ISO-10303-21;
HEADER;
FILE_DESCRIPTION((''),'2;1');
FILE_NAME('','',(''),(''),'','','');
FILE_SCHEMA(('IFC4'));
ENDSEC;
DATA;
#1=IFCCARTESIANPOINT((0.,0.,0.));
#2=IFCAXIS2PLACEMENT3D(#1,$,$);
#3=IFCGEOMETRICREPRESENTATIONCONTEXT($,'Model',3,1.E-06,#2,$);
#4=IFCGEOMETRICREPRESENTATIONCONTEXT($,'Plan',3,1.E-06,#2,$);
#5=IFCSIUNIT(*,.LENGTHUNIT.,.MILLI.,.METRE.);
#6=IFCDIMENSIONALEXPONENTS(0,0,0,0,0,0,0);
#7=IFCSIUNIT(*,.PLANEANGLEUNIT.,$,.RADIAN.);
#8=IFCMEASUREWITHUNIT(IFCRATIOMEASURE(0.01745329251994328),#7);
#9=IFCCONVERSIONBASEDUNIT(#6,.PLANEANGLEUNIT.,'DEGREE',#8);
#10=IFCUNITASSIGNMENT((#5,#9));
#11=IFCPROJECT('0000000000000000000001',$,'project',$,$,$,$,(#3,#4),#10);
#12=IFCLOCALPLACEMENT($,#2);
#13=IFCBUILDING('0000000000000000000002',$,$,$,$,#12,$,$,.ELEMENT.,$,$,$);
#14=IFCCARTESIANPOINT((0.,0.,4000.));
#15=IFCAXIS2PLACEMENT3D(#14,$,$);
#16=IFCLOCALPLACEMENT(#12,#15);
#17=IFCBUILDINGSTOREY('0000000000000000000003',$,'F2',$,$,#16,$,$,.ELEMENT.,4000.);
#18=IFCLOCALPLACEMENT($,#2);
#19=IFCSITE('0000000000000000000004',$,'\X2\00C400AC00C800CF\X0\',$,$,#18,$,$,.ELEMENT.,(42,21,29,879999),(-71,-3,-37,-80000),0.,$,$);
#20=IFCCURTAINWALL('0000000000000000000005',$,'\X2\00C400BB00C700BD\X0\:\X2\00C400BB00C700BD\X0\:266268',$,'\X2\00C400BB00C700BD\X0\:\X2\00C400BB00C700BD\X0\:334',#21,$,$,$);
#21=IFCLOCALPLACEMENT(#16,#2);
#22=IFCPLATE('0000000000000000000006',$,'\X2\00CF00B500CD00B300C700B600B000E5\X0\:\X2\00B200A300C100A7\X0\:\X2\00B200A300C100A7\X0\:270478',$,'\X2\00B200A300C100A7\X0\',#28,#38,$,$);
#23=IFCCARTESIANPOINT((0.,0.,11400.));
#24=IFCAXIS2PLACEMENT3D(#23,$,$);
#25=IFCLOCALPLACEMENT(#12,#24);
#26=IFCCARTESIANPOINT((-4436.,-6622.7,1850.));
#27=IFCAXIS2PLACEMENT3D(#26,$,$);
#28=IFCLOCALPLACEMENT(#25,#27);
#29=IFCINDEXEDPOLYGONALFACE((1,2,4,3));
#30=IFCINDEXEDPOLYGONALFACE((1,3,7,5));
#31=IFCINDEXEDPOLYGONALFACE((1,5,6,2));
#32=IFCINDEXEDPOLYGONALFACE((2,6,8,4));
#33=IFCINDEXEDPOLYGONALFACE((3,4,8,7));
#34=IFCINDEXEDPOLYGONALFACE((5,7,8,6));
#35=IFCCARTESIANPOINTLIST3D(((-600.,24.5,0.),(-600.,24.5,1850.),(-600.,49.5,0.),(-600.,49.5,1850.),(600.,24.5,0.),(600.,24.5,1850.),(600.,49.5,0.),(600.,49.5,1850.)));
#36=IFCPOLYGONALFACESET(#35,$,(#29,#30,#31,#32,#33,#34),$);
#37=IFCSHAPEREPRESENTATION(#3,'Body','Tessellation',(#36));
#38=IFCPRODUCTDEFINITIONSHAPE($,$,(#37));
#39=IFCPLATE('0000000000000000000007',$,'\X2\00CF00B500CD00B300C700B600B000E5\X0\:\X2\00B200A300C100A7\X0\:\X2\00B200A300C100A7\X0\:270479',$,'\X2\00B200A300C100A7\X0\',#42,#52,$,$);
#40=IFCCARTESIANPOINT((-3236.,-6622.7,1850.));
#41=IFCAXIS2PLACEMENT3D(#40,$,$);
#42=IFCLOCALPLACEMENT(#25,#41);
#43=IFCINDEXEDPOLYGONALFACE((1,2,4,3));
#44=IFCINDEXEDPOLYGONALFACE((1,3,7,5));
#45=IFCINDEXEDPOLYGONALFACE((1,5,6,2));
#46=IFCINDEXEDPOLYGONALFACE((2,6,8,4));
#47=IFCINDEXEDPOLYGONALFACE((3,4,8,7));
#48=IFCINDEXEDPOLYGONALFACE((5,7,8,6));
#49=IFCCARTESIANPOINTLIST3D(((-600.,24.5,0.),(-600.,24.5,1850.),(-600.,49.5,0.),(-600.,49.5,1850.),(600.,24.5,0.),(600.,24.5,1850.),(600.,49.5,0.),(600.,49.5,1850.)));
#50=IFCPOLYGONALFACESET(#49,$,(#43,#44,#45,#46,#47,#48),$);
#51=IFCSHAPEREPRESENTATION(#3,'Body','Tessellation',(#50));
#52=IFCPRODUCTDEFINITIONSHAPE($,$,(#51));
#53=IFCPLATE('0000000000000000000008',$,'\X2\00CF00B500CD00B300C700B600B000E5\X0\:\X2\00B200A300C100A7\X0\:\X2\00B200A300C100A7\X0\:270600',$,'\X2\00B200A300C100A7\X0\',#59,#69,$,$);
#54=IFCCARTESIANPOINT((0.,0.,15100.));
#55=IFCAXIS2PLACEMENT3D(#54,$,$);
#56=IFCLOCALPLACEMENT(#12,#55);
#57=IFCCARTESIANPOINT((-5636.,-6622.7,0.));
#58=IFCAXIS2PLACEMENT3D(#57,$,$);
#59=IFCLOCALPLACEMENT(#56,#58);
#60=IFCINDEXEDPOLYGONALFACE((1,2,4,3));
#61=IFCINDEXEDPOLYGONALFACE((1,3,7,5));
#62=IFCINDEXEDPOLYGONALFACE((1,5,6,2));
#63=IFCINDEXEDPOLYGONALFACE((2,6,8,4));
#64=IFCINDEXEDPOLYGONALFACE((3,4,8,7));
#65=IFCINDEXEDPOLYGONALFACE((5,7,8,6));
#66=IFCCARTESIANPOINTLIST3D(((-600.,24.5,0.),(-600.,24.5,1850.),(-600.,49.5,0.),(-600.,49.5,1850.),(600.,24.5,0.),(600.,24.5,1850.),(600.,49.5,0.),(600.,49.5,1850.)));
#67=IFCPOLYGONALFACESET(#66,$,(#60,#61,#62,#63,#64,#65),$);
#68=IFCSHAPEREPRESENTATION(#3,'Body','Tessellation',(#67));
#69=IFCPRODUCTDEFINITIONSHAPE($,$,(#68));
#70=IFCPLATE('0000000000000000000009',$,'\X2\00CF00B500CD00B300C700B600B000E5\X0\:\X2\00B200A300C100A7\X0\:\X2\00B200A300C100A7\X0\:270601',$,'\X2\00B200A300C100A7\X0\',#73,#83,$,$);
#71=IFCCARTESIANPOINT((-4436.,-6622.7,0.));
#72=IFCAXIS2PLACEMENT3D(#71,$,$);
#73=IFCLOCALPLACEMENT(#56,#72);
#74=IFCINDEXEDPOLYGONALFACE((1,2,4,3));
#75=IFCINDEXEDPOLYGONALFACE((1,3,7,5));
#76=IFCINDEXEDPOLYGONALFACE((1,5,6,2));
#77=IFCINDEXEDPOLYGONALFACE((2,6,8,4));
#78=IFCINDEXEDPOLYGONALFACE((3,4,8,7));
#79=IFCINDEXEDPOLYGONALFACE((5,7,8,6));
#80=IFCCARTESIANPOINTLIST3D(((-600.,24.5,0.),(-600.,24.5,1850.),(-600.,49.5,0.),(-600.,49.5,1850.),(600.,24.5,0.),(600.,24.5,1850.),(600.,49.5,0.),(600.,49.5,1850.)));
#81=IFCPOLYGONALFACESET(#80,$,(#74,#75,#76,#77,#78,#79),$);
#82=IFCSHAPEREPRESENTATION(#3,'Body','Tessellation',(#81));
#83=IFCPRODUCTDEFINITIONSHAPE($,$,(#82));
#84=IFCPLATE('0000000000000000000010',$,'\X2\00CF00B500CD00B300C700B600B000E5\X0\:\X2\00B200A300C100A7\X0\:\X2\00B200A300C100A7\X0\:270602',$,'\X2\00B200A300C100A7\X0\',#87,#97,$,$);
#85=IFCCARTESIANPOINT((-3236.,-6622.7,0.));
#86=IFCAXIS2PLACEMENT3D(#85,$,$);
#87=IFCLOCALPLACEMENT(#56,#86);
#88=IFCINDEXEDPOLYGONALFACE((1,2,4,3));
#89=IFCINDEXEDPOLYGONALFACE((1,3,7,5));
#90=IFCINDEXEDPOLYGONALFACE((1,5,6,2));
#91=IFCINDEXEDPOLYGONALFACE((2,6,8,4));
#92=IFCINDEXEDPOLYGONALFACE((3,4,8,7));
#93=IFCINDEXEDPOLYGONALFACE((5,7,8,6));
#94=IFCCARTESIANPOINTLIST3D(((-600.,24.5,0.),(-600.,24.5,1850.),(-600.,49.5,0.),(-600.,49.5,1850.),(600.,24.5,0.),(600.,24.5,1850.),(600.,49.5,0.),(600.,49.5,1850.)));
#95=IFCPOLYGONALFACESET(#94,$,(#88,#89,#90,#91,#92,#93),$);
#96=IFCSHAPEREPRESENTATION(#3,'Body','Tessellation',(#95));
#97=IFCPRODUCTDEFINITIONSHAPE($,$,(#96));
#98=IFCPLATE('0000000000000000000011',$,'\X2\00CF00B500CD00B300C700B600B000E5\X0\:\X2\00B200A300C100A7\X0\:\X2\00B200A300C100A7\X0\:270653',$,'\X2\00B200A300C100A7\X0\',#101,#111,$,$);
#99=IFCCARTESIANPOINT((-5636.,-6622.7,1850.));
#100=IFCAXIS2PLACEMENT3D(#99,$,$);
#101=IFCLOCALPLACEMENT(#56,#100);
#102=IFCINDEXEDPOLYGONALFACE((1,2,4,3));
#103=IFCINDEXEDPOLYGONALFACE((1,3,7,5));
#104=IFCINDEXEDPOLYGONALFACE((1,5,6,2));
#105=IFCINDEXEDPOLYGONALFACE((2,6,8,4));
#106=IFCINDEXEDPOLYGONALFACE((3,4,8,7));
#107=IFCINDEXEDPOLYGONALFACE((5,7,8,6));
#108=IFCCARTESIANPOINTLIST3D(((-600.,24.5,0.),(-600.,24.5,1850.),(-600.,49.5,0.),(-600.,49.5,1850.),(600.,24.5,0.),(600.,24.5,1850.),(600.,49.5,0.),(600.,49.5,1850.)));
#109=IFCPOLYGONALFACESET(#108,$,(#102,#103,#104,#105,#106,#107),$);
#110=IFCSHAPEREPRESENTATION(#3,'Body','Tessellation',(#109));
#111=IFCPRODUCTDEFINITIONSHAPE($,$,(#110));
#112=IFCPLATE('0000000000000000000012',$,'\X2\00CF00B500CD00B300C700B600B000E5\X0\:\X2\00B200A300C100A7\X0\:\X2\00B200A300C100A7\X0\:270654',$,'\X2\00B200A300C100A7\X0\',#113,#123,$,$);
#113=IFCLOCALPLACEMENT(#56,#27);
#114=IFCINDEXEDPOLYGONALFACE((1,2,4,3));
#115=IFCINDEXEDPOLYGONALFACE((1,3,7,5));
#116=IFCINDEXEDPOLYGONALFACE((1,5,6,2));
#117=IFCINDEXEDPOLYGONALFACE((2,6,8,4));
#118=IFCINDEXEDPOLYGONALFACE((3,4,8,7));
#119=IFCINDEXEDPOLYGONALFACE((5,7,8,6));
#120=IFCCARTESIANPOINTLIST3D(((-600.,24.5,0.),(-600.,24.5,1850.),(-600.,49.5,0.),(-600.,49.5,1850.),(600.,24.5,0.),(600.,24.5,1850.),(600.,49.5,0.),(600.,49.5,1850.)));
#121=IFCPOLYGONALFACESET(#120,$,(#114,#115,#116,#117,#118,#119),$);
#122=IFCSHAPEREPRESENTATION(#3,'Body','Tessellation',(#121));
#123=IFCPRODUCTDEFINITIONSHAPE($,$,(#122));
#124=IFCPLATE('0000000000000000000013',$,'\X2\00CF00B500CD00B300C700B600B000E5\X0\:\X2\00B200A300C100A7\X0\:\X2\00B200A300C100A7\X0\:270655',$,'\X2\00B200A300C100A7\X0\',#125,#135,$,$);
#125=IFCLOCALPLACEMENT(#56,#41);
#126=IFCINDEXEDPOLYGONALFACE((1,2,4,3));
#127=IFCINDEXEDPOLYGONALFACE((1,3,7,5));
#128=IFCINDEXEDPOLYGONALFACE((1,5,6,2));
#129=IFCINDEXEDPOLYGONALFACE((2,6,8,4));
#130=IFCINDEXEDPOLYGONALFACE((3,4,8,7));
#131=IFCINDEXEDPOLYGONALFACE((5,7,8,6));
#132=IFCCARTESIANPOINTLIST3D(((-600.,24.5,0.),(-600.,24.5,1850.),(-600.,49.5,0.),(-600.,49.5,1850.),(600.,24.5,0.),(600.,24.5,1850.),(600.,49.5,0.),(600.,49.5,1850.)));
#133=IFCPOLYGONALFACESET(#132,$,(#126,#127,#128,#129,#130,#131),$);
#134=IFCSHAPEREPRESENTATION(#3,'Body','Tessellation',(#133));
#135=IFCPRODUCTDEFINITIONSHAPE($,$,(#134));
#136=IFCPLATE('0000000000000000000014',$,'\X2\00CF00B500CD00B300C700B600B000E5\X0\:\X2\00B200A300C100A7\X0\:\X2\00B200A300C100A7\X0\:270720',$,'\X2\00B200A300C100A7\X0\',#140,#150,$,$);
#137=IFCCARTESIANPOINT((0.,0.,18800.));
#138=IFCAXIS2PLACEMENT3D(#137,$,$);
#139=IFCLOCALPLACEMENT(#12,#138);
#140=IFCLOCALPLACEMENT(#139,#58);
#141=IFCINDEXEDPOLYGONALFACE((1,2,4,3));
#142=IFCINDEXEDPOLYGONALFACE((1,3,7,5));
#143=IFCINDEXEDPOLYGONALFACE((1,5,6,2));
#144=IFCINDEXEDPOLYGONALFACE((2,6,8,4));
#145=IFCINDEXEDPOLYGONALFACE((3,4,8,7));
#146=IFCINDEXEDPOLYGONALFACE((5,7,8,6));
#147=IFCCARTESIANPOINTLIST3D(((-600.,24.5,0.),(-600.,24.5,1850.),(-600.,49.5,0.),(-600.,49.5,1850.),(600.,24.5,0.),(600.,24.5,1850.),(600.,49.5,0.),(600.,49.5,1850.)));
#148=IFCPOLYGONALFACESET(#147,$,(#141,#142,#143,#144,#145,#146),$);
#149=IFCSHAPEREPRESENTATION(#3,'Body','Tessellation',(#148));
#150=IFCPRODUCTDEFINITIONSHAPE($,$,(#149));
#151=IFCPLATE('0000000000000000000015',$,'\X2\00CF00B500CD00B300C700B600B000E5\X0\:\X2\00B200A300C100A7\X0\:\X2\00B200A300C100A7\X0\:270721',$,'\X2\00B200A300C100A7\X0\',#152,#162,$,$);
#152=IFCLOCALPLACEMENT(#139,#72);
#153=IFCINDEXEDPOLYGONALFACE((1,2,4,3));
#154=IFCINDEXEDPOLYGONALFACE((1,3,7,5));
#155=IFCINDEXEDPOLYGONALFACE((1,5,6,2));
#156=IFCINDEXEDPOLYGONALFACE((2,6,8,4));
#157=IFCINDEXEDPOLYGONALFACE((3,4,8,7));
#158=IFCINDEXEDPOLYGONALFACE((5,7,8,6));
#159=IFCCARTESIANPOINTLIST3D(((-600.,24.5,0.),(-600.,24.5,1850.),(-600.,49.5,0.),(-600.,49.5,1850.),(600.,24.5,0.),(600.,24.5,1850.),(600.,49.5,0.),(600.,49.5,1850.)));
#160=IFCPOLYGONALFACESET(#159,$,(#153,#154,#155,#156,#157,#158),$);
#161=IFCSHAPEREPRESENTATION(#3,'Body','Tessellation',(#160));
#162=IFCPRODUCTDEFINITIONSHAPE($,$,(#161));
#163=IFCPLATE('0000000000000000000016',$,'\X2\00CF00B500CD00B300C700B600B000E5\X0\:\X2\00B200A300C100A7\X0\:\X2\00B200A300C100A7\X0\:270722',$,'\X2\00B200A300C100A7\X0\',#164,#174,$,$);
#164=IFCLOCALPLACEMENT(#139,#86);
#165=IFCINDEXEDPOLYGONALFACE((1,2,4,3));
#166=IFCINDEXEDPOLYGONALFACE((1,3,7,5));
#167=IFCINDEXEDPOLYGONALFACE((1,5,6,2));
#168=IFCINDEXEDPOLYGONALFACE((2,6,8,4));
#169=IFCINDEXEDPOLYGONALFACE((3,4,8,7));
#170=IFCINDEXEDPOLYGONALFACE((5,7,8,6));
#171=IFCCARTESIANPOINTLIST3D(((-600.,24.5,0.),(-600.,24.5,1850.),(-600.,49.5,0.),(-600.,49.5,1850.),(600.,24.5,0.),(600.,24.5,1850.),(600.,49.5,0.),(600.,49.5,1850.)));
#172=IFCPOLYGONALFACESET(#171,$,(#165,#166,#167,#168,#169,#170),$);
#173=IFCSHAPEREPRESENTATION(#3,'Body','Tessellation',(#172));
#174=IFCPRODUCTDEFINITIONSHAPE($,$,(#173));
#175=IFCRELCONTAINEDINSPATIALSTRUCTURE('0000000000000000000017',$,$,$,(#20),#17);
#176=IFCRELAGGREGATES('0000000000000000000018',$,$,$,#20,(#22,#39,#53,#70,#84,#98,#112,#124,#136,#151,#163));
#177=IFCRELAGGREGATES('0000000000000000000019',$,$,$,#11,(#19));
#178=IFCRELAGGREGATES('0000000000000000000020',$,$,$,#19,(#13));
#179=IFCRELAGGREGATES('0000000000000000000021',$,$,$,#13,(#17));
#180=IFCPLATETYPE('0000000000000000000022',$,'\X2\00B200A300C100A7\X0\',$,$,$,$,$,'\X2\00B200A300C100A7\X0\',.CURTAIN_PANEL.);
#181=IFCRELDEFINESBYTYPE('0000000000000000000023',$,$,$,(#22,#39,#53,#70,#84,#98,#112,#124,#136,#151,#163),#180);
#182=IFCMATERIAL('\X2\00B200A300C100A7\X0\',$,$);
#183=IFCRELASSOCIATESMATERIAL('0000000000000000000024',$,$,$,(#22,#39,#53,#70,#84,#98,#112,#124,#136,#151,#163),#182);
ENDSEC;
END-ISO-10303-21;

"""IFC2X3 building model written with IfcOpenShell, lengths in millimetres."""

from ifc_helpers import new_model, entity, si_unit, converted_unit, frame, origin, origin_2d_with_axis, place, context, project, spatial, rectangle, extrude, source, transform, mapped, material, type_object, type_shapes, element, aggregate, save


model = new_model("IFC2X3")

# Units and contexts
model_context = context("Model", 3, precision=1e-06, world=origin())
plan_context = context("Plan", 3, precision=1e-06, world=origin())
ifc_project = project(units=[si_unit("LENGTHUNIT", "METRE", prefix="MILLI"), converted_unit("PLANEANGLEUNIT", "DEGREE", entity("IfcRatioMeasure", 0.01745329251994328), si_unit("PLANEANGLEUNIT", "RADIAN"), dimensions=[0, 0, 0, 0, 0, 0, 0])], contexts=[model_context, plan_context])

# Site, building, storey
site_placement = place(None, origin())
site = spatial("IfcSite", under=ifc_project, at=site_placement, Name="Ä¬ÈÏ", CompositionType="ELEMENT", RefLatitude=(42, 21, 29, 879999), RefLongitude=(-71, -3, -37, -80000), RefElevation=0.0)
building_placement = place(None, origin())
building = spatial("IfcBuilding", under=site, at=building_placement, CompositionType="ELEMENT")
storey_placement = place(building_placement, frame((0.0, 0.0, 4000.0)))
storey = spatial("IfcBuildingStorey", under=building, at=storey_placement, Name="F2", CompositionType="ELEMENT", Elevation=4000.0)

# Curtain wall, plates
curtain_wall_placement = place(storey_placement, origin())
curtain_wall = element("IfcCurtainWall", 1, at=curtain_wall_placement, inside=storey, Name="Ä»Ç½:Ä»Ç½:266268", ObjectType="Ä»Ç½:Ä»Ç½:334")
placement_1 = place(building_placement, frame((0.0, 0.0, 11400.0)))
placement_2 = place(building_placement, frame((0.0, 0.0, 15100.0)))
placement_3 = place(building_placement, frame((0.0, 0.0, 18800.0)))
ifc_material_1 = material(Name="²£Á§")
plate_type = type_object("IfcPlateType", Name="²£Á§", ElementType="²£Á§", PredefinedType="CURTAIN_PANEL")
shared_shape_1 = source(origin(), model_context, "Body", "SweptSolid", [
    extrude(rectangle(XDim=25.0, YDim=1200.0, at=origin_2d_with_axis()), frame((0.0, 37.0, 0.0), z_axis=(0.0, 0.0, 1.0), x_axis=(0.0, 1.0, 0.0)), (0.0, 0.0, 1.0), 1850.0),
])
type_shapes(plate_type, [shared_shape_1])
plate_1_placement = place(placement_1, frame((-4436.0, -6622.7, 1850.0)))
plate_1 = element("IfcPlate", 2, at=plate_1_placement, type_object=plate_type, material=ifc_material_1, Name="ÏµÍ³Ç¶°å:²£Á§:²£Á§:270478", ObjectType="²£Á§", context=model_context, shape_type="MappedRepresentation", body=[
    mapped(shared_shape_1, transform((0.0, 0.0, 0.0), scale=1.0)),
])
plate_2_placement = place(placement_1, frame((-3236.0, -6622.7, 1850.0)))
plate_2 = element("IfcPlate", 3, at=plate_2_placement, type_object=plate_type, material=ifc_material_1, Name="ÏµÍ³Ç¶°å:²£Á§:²£Á§:270479", ObjectType="²£Á§", context=model_context, shape_type="MappedRepresentation", body=[
    mapped(shared_shape_1, transform((0.0, 0.0, 0.0), scale=1.0)),
])
plate_3_placement = place(placement_2, frame((-5636.0, -6622.7, 0.0)))
plate_3 = element("IfcPlate", 4, at=plate_3_placement, type_object=plate_type, material=ifc_material_1, Name="ÏµÍ³Ç¶°å:²£Á§:²£Á§:270600", ObjectType="²£Á§", context=model_context, shape_type="MappedRepresentation", body=[
    mapped(shared_shape_1, transform((0.0, 0.0, 0.0), scale=1.0)),
])
plate_4_placement = place(placement_2, frame((-4436.0, -6622.7, 0.0)))
plate_4 = element("IfcPlate", 5, at=plate_4_placement, type_object=plate_type, material=ifc_material_1, Name="ÏµÍ³Ç¶°å:²£Á§:²£Á§:270601", ObjectType="²£Á§", context=model_context, shape_type="MappedRepresentation", body=[
    mapped(shared_shape_1, transform((0.0, 0.0, 0.0), scale=1.0)),
])
plate_5_placement = place(placement_2, frame((-3236.0, -6622.7, 0.0)))
plate_5 = element("IfcPlate", 6, at=plate_5_placement, type_object=plate_type, material=ifc_material_1, Name="ÏµÍ³Ç¶°å:²£Á§:²£Á§:270602", ObjectType="²£Á§", context=model_context, shape_type="MappedRepresentation", body=[
    mapped(shared_shape_1, transform((0.0, 0.0, 0.0), scale=1.0)),
])
plate_6_placement = place(placement_2, frame((-5636.0, -6622.7, 1850.0)))
plate_6 = element("IfcPlate", 7, at=plate_6_placement, type_object=plate_type, material=ifc_material_1, Name="ÏµÍ³Ç¶°å:²£Á§:²£Á§:270653", ObjectType="²£Á§", context=model_context, shape_type="MappedRepresentation", body=[
    mapped(shared_shape_1, transform((0.0, 0.0, 0.0), scale=1.0)),
])
plate_7_placement = place(placement_2, frame((-4436.0, -6622.7, 1850.0)))
plate_7 = element("IfcPlate", 8, at=plate_7_placement, type_object=plate_type, material=ifc_material_1, Name="ÏµÍ³Ç¶°å:²£Á§:²£Á§:270654", ObjectType="²£Á§", context=model_context, shape_type="MappedRepresentation", body=[
    mapped(shared_shape_1, transform((0.0, 0.0, 0.0), scale=1.0)),
])
plate_8_placement = place(placement_2, frame((-3236.0, -6622.7, 1850.0)))
plate_8 = element("IfcPlate", 9, at=plate_8_placement, type_object=plate_type, material=ifc_material_1, Name="ÏµÍ³Ç¶°å:²£Á§:²£Á§:270655", ObjectType="²£Á§", context=model_context, shape_type="MappedRepresentation", body=[
    mapped(shared_shape_1, transform((0.0, 0.0, 0.0), scale=1.0)),
])
plate_9_placement = place(placement_3, frame((-5636.0, -6622.7, 0.0)))
plate_9 = element("IfcPlate", 10, at=plate_9_placement, type_object=plate_type, material=ifc_material_1, Name="ÏµÍ³Ç¶°å:²£Á§:²£Á§:270720", ObjectType="²£Á§", context=model_context, shape_type="MappedRepresentation", body=[
    mapped(shared_shape_1, transform((0.0, 0.0, 0.0), scale=1.0)),
])
plate_10_placement = place(placement_3, frame((-4436.0, -6622.7, 0.0)))
plate_10 = element("IfcPlate", 11, at=plate_10_placement, type_object=plate_type, material=ifc_material_1, Name="ÏµÍ³Ç¶°å:²£Á§:²£Á§:270721", ObjectType="²£Á§", context=model_context, shape_type="MappedRepresentation", body=[
    mapped(shared_shape_1, transform((0.0, 0.0, 0.0), scale=1.0)),
])
plate_11_placement = place(placement_3, frame((-3236.0, -6622.7, 0.0)))
plate_11 = element("IfcPlate", 12, at=plate_11_placement, type_object=plate_type, material=ifc_material_1, Name="ÏµÍ³Ç¶°å:²£Á§:²£Á§:270722", ObjectType="²£Á§", context=model_context, shape_type="MappedRepresentation", body=[
    mapped(shared_shape_1, transform((0.0, 0.0, 0.0), scale=1.0)),
])
aggregate(curtain_wall, [plate_1, plate_2, plate_3, plate_4, plate_5, plate_6, plate_7, plate_8, plate_9, plate_10, plate_11])

save(model, "model.ifc")
